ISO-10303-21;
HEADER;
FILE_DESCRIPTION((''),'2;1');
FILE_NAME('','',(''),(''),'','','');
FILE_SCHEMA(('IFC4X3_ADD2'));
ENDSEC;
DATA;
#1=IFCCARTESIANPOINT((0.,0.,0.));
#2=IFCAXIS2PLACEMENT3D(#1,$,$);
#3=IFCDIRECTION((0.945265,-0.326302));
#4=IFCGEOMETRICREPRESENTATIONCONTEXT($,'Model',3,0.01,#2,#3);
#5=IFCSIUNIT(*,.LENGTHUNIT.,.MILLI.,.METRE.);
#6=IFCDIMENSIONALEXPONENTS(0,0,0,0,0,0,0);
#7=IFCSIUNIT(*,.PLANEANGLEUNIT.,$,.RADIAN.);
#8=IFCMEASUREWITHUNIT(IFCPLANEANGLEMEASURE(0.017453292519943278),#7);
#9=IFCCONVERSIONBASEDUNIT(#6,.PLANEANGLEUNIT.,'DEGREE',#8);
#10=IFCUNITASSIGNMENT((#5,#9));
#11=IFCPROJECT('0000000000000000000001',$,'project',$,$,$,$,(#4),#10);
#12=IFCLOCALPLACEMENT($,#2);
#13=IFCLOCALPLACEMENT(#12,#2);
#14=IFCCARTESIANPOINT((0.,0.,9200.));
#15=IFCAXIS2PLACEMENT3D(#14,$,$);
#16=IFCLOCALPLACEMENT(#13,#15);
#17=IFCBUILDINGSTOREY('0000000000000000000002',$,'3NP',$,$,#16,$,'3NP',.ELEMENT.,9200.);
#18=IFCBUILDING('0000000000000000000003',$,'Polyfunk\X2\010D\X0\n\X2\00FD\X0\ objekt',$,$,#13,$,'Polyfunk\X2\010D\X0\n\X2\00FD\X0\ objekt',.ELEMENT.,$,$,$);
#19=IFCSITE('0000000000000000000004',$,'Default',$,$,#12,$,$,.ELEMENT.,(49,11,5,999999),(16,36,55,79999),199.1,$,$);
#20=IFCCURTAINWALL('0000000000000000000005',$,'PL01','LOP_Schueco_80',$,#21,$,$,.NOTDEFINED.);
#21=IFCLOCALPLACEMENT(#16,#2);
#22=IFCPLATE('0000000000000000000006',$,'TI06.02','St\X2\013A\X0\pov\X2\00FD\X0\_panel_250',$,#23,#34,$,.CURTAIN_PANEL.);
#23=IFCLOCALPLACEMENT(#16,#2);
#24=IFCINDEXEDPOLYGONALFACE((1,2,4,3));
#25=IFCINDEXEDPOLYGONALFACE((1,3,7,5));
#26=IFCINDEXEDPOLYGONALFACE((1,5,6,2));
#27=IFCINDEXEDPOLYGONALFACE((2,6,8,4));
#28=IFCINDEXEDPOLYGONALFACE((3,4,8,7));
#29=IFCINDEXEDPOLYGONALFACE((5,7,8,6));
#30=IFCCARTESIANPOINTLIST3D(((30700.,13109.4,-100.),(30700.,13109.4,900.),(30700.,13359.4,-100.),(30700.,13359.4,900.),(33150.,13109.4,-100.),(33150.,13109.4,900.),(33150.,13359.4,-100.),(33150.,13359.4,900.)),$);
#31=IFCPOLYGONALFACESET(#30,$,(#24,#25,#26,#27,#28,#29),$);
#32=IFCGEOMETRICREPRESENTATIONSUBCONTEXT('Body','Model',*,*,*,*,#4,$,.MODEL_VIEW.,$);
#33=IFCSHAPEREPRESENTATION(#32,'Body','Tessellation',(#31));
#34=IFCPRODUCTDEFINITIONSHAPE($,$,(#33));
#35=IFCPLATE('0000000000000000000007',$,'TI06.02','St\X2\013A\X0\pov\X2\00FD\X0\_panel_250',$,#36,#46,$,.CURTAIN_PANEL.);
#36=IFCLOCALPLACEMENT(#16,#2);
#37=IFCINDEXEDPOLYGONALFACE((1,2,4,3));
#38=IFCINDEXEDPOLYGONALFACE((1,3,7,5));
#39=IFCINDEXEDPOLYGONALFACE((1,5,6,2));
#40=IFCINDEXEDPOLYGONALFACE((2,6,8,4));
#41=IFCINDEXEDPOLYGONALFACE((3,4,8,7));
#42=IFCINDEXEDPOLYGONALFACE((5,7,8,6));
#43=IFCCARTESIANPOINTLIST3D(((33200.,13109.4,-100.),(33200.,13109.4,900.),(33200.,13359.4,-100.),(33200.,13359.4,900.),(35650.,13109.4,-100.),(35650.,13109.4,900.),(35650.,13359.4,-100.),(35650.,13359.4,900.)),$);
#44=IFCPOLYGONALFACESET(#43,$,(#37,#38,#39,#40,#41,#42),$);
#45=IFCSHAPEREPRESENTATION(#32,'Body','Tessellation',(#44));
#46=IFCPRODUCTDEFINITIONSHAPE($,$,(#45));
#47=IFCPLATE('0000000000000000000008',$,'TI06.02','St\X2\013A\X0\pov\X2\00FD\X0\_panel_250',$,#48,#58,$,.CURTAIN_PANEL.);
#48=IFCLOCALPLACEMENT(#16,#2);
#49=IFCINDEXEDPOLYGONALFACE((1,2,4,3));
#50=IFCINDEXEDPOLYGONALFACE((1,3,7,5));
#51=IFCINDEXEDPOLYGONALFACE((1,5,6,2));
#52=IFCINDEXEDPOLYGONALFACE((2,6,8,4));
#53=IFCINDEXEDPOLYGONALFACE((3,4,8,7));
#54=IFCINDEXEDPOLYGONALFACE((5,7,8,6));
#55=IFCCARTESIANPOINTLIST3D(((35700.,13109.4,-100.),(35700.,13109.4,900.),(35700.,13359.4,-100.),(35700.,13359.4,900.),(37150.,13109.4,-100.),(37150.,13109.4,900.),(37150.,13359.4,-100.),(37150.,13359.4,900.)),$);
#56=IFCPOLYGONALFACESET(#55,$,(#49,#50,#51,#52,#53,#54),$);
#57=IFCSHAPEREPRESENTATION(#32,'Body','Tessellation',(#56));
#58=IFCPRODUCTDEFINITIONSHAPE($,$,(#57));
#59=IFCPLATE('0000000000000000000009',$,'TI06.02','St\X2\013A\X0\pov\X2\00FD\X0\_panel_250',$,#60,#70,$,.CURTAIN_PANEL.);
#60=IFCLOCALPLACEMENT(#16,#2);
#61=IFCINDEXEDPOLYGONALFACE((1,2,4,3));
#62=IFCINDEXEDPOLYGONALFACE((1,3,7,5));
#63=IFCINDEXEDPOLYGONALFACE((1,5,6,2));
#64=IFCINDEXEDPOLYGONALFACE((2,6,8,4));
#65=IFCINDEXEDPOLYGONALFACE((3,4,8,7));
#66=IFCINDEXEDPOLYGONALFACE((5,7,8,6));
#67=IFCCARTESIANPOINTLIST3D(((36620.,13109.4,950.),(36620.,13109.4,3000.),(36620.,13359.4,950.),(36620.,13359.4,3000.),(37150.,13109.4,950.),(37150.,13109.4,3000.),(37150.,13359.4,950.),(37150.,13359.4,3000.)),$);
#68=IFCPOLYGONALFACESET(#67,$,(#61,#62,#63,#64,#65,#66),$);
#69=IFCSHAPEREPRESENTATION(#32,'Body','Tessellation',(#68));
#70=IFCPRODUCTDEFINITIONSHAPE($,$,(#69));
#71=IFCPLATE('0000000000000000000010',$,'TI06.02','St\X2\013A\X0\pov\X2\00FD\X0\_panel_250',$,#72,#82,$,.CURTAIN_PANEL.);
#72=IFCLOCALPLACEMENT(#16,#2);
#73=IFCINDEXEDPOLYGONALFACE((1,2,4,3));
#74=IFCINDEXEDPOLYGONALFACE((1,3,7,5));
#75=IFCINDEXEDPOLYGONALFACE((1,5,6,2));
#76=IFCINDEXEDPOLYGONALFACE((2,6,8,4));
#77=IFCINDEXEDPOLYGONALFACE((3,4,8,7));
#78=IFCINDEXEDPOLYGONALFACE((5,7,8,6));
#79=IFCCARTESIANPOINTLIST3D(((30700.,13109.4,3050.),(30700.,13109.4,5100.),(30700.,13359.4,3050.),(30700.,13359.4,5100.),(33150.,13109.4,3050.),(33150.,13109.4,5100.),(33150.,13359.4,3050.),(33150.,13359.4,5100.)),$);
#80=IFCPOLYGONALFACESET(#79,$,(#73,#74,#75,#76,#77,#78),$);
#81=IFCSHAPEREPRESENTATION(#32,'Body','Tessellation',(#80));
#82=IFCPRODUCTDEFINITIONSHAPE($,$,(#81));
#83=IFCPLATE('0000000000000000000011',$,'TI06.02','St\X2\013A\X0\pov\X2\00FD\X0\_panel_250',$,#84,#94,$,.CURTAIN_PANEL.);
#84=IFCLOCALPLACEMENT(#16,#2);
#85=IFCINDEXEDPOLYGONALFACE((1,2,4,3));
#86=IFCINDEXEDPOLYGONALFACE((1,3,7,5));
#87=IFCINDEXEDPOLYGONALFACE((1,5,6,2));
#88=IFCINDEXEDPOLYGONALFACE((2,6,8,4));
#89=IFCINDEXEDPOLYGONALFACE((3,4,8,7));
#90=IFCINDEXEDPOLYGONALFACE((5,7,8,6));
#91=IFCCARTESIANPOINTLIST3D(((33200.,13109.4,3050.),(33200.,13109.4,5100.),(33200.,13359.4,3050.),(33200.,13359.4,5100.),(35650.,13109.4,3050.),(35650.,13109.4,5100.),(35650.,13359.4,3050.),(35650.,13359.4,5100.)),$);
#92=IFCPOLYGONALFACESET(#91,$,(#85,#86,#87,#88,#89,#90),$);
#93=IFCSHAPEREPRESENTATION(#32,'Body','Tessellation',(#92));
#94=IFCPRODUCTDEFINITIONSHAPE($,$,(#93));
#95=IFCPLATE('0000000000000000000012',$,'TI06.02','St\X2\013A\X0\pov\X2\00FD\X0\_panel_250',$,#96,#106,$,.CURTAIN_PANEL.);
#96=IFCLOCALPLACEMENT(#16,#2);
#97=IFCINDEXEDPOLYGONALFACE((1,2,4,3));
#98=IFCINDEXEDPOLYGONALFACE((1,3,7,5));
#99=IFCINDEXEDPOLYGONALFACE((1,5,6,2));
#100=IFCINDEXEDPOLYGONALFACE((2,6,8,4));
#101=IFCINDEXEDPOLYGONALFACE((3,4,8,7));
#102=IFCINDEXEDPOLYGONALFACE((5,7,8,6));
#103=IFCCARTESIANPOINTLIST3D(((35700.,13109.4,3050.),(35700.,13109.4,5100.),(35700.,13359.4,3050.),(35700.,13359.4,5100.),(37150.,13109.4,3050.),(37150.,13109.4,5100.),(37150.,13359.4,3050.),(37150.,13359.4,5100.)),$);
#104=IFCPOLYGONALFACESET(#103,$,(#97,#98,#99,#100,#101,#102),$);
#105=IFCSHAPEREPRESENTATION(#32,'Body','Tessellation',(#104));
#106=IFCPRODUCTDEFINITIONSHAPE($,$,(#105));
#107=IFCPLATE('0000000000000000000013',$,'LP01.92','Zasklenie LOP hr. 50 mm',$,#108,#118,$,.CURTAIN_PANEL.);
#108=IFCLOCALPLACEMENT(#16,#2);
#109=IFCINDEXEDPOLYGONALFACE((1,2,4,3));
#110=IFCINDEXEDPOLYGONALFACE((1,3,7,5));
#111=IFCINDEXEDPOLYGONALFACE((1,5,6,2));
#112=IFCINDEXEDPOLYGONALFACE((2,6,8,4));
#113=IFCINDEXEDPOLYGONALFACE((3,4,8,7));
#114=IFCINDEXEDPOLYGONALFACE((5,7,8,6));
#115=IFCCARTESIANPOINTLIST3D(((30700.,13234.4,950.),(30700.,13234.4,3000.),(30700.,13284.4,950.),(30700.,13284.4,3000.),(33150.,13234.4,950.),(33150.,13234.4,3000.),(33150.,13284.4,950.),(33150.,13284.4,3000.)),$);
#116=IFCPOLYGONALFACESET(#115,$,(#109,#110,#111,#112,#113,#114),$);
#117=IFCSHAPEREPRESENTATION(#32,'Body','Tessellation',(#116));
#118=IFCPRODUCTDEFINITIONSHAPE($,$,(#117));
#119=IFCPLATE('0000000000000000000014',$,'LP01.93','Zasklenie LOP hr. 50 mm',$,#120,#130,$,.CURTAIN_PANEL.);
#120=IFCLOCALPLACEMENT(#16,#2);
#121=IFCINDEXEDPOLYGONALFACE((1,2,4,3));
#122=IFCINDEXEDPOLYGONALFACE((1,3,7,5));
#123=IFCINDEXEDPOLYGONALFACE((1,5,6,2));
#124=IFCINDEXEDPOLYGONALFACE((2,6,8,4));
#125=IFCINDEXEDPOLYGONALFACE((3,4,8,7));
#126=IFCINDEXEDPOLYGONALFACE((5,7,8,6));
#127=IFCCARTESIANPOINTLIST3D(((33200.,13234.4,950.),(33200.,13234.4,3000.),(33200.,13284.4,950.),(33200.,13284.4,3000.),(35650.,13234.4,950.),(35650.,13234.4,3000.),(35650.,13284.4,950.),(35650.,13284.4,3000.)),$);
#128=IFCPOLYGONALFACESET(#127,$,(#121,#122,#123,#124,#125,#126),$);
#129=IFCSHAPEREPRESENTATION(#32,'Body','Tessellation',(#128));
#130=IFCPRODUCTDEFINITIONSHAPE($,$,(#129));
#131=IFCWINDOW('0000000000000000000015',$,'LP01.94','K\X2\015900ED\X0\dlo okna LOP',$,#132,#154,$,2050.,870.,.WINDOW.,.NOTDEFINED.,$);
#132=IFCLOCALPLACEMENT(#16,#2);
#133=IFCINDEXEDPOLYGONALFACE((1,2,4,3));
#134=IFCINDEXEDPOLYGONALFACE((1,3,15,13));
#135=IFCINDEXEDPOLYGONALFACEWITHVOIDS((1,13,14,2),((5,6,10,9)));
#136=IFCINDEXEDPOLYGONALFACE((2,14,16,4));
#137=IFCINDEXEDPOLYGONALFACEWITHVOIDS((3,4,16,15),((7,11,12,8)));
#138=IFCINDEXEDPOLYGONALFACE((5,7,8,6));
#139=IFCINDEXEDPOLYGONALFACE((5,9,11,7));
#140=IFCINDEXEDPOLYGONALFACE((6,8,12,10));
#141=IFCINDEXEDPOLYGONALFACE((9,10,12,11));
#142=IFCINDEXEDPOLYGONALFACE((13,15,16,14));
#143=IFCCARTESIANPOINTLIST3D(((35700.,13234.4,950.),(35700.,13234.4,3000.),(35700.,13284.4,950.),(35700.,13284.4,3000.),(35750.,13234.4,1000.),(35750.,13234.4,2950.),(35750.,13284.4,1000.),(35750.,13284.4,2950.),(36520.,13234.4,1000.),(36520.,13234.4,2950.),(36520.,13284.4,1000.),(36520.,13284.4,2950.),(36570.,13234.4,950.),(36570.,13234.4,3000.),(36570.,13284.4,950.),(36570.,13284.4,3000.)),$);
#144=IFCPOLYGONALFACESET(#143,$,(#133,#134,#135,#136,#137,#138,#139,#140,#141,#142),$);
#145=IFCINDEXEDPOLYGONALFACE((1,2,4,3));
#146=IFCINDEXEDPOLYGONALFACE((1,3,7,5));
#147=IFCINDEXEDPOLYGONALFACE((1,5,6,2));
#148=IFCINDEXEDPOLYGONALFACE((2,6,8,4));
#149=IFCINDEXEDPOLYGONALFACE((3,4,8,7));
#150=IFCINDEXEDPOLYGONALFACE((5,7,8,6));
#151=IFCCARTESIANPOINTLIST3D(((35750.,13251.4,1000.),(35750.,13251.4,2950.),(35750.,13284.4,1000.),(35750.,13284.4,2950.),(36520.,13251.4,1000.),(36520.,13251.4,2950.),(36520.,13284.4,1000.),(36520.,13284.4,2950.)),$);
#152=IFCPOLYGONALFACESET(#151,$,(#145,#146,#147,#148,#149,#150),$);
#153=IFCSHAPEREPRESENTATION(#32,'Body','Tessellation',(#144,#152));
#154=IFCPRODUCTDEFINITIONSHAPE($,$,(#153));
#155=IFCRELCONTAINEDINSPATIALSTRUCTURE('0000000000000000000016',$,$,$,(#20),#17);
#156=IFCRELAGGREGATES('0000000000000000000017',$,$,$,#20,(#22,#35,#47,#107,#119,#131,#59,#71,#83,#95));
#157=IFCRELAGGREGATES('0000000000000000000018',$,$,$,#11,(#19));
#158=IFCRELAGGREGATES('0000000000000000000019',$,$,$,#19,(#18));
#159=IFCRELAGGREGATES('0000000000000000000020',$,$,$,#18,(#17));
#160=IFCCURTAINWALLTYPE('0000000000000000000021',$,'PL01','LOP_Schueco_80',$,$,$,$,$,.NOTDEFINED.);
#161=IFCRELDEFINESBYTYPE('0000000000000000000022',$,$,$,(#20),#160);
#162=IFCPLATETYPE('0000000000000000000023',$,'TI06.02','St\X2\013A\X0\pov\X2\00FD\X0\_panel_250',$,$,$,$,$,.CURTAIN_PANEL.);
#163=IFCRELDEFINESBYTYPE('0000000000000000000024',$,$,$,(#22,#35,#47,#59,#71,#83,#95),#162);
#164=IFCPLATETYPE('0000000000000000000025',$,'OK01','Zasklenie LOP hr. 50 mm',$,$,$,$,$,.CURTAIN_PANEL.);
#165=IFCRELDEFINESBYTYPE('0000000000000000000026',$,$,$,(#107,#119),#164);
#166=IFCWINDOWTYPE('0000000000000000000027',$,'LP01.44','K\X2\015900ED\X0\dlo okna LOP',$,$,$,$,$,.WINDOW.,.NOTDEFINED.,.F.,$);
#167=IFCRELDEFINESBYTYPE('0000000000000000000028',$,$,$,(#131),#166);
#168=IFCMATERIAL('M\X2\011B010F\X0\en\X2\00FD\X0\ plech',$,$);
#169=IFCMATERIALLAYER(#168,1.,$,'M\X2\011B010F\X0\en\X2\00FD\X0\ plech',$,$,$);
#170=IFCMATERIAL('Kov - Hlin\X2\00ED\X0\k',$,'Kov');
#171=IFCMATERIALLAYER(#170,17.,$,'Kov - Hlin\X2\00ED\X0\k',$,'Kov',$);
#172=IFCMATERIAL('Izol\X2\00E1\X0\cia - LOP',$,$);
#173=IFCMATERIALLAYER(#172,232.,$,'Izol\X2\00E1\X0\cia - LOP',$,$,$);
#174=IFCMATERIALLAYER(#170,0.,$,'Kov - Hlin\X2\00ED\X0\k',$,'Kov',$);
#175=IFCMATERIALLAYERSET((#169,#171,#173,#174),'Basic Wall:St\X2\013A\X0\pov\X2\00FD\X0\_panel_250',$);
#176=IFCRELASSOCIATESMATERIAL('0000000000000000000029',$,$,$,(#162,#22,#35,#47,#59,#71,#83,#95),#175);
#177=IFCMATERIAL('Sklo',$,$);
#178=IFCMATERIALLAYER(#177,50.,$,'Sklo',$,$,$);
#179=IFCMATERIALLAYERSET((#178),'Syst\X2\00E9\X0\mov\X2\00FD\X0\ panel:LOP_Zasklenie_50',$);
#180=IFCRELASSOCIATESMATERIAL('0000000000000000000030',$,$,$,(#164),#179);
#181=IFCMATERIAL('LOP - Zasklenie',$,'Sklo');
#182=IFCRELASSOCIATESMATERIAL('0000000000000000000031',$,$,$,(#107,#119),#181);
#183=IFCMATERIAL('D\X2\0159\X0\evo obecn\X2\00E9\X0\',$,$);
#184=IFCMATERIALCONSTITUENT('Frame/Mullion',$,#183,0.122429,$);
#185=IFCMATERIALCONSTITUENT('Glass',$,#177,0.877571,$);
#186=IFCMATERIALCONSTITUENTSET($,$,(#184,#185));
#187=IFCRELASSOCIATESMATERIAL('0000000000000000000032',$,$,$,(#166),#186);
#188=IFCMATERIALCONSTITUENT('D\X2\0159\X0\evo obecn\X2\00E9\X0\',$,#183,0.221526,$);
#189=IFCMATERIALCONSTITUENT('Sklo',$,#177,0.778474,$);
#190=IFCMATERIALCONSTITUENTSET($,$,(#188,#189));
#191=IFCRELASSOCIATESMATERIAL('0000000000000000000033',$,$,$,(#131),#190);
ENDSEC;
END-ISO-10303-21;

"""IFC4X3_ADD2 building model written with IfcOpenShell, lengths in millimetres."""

from ifc_helpers import new_model, entity, si_unit, converted_unit, direction, frame, frame_2d, origin, origin_2d_with_axis, place, context, subcontext, project, spatial, polyline, rectangle, outline, extrude, source, transform, mapped, material, layer, layer_set, layer_usage, constituent, constituent_set, type_object, type_shapes, element, aggregate, save


model = new_model("IFC4X3_ADD2")

# Units and contexts
model_context = context("Model", 3, precision=0.01, world=origin(), true_north=direction((0.945265, -0.326302)))
body_context = subcontext(model_context, "Body", "Model", "MODEL_VIEW")
ifc_project = project(units=[si_unit("LENGTHUNIT", "METRE", prefix="MILLI"), converted_unit("PLANEANGLEUNIT", "DEGREE", entity("IfcPlaneAngleMeasure", 0.017453292519943278), si_unit("PLANEANGLEUNIT", "RADIAN"), dimensions=[0, 0, 0, 0, 0, 0, 0])], contexts=[model_context])

# Site, building, storey
site_placement = place(None, origin())
site = spatial("IfcSite", under=ifc_project, at=site_placement, Name="Default", CompositionType="ELEMENT", RefLatitude=(49, 11, 5, 999999), RefLongitude=(16, 36, 55, 79999), RefElevation=199.1)
building_placement = place(site_placement, origin())
building = spatial("IfcBuilding", under=site, at=building_placement, Name="Polyfunkčný objekt", LongName="Polyfunkčný objekt", CompositionType="ELEMENT")
storey_placement = place(building_placement, frame((0.0, 0.0, 9200.0)))
storey = spatial("IfcBuildingStorey", under=building, at=storey_placement, Name="3NP", LongName="3NP", CompositionType="ELEMENT", Elevation=9200.0)

# Curtain wall, plates, window
curtain_wall_type = type_object("IfcCurtainWallType", Name="PL01", Description="LOP_Schueco_80", PredefinedType="NOTDEFINED")
curtain_wall_placement = place(storey_placement, frame((0.0, 0.0, -9200.0)))
curtain_wall = element("IfcCurtainWall", 1, at=curtain_wall_placement, inside=storey, type_object=curtain_wall_type, Name="PL01", Description="LOP_Schueco_80", PredefinedType="NOTDEFINED")
ifc_material_1 = material(Name="Měďený plech")
ifc_layer_1 = layer(ifc_material_1, 1.0, Name="Měďený plech")
ifc_material_2 = material(Name="Kov - Hliník", Category="Kov")
ifc_layer_2 = layer(ifc_material_2, 17.0, Name="Kov - Hliník", Category="Kov")
ifc_material_3 = material(Name="Izolácia - LOP")
ifc_layer_3 = layer(ifc_material_3, 232.0, Name="Izolácia - LOP")
ifc_layer_4 = layer(ifc_material_2, 0.0, Name="Kov - Hliník", Category="Kov")
ifc_layer_set_1 = layer_set([ifc_layer_1, ifc_layer_2, ifc_layer_3, ifc_layer_4], Name="Basic Wall:Stĺpový_panel_250")
ifc_layer_usage_1 = layer_usage(ifc_layer_set_1, "AXIS2", "NEGATIVE", 125.0)
plate_type_1 = type_object("IfcPlateType", Name="TI06.02", Description="Stĺpový_panel_250", PredefinedType="CURTAIN_PANEL", material=ifc_layer_set_1)
plate_1_placement = place(storey_placement, frame((30700.0, 13234.4, -100.0)))
plate_1 = element("IfcPlate", 2, at=plate_1_placement, type_object=plate_type_1, material=ifc_layer_usage_1, Name="TI06.02", Description="Stĺpový_panel_250", PredefinedType="CURTAIN_PANEL", context=body_context, shape_type="SweptSolid", body=[
    extrude(rectangle(XDim=250.0, YDim=2450.0, at=frame_2d((0.0, 0.0), x_axis=(1.0, 0.0))), frame((1225.0, 0.0, 0.0), z_axis=(0.0, 0.0, 1.0), x_axis=(0.0, 1.0, 0.0)), (0.0, 0.0, 1.0), 1000.0),
])
ifc_layer_usage_2 = layer_usage(ifc_layer_set_1, "AXIS2", "NEGATIVE", 125.0)
plate_2_placement = place(storey_placement, frame((33200.0, 13234.4, -100.0)))
plate_2 = element("IfcPlate", 3, at=plate_2_placement, type_object=plate_type_1, material=ifc_layer_usage_2, Name="TI06.02", Description="Stĺpový_panel_250", PredefinedType="CURTAIN_PANEL", context=body_context, shape_type="SweptSolid", body=[
    extrude(rectangle(XDim=250.0, YDim=2450.0, at=frame_2d((0.0, 0.0), x_axis=(1.0, 0.0))), frame((1225.0, 0.0, 0.0), z_axis=(0.0, 0.0, 1.0), x_axis=(0.0, 1.0, 0.0)), (0.0, 0.0, 1.0), 1000.0),
])
ifc_layer_usage_3 = layer_usage(ifc_layer_set_1, "AXIS2", "NEGATIVE", 125.0)
plate_3_placement = place(storey_placement, frame((35700.0, 13234.4, -100.0)))
plate_3 = element("IfcPlate", 4, at=plate_3_placement, type_object=plate_type_1, material=ifc_layer_usage_3, Name="TI06.02", Description="Stĺpový_panel_250", PredefinedType="CURTAIN_PANEL", context=body_context, shape_type="SweptSolid", body=[
    extrude(rectangle(XDim=250.0, YDim=1450.0, at=origin_2d_with_axis()), frame((725.0, 0.0, 0.0), z_axis=(0.0, 0.0, 1.0), x_axis=(0.0, 1.0, 0.0)), (0.0, 0.0, 1.0), 1000.0),
])
ifc_layer_usage_4 = layer_usage(ifc_layer_set_1, "AXIS2", "NEGATIVE", 125.0)
plate_4_placement = place(storey_placement, frame((36620.0, 13234.4, 950.0)))
plate_4 = element("IfcPlate", 5, at=plate_4_placement, type_object=plate_type_1, material=ifc_layer_usage_4, Name="TI06.02", Description="Stĺpový_panel_250", PredefinedType="CURTAIN_PANEL", context=body_context, shape_type="SweptSolid", body=[
    extrude(rectangle(XDim=250.0, YDim=530.0, at=frame_2d((0.0, 0.0), x_axis=(1.0, 0.0))), frame((265.0, 0.0, 0.0), z_axis=(0.0, 0.0, 1.0), x_axis=(0.0, 1.0, 0.0)), (0.0, 0.0, 1.0), 2050.0),
])
ifc_layer_usage_5 = layer_usage(ifc_layer_set_1, "AXIS2", "NEGATIVE", 125.0)
plate_5_placement = place(storey_placement, frame((30700.0, 13234.4, 3050.0)))
plate_5 = element("IfcPlate", 6, at=plate_5_placement, type_object=plate_type_1, material=ifc_layer_usage_5, Name="TI06.02", Description="Stĺpový_panel_250", PredefinedType="CURTAIN_PANEL", context=body_context, shape_type="SweptSolid", body=[
    extrude(rectangle(XDim=250.0, YDim=2450.0, at=frame_2d((0.0, 0.0), x_axis=(1.0, 0.0))), frame((1225.0, 0.0, 0.0), z_axis=(0.0, 0.0, 1.0), x_axis=(0.0, 1.0, 0.0)), (0.0, 0.0, 1.0), 2050.0),
])
ifc_layer_usage_6 = layer_usage(ifc_layer_set_1, "AXIS2", "NEGATIVE", 125.0)
plate_6_placement = place(storey_placement, frame((33200.0, 13234.4, 3050.0)))
plate_6 = element("IfcPlate", 7, at=plate_6_placement, type_object=plate_type_1, material=ifc_layer_usage_6, Name="TI06.02", Description="Stĺpový_panel_250", PredefinedType="CURTAIN_PANEL", context=body_context, shape_type="SweptSolid", body=[
    extrude(rectangle(XDim=250.0, YDim=2450.0, at=frame_2d((0.0, 0.0), x_axis=(1.0, 0.0))), frame((1225.0, 0.0, 0.0), z_axis=(0.0, 0.0, 1.0), x_axis=(0.0, 1.0, 0.0)), (0.0, 0.0, 1.0), 2050.0),
])
ifc_layer_usage_7 = layer_usage(ifc_layer_set_1, "AXIS2", "NEGATIVE", 125.0)
plate_7_placement = place(storey_placement, frame((35700.0, 13234.4, 3050.0)))
plate_7 = element("IfcPlate", 8, at=plate_7_placement, type_object=plate_type_1, material=ifc_layer_usage_7, Name="TI06.02", Description="Stĺpový_panel_250", PredefinedType="CURTAIN_PANEL", context=body_context, shape_type="SweptSolid", body=[
    extrude(rectangle(XDim=250.0, YDim=1450.0, at=origin_2d_with_axis()), frame((725.0, 0.0, 0.0), z_axis=(0.0, 0.0, 1.0), x_axis=(0.0, 1.0, 0.0)), (0.0, 0.0, 1.0), 2050.0),
])
ifc_material_4 = material(Name="LOP - Zasklenie", Category="Sklo")
ifc_material_5 = material(Name="Sklo")
ifc_layer_5 = layer(ifc_material_5, 50.0, Name="Sklo")
ifc_layer_set_2 = layer_set([ifc_layer_5], Name="Systémový panel:LOP_Zasklenie_50")
plate_type_2 = type_object("IfcPlateType", Name="OK01", Description="Zasklenie LOP hr. 50 mm", PredefinedType="CURTAIN_PANEL", material=ifc_layer_set_2)
shared_shape_1 = source(origin(), body_context, "Body", "SweptSolid", [
    extrude(rectangle(XDim=50.0, YDim=2450.0, at=origin_2d_with_axis()), frame((0.0, 25.0, 0.0), z_axis=(0.0, 0.0, 1.0), x_axis=(0.0, 1.0, 0.0)), (0.0, 0.0, 1.0), 2050.0),
])
type_shapes(plate_type_2, [shared_shape_1])
plate_8_placement = place(curtain_wall_placement, frame((31925.0, 13234.4, 10150.0)))
plate_8 = element("IfcPlate", 9, at=plate_8_placement, type_object=plate_type_2, material=ifc_material_4, Name="LP01.92", Description="Zasklenie LOP hr. 50 mm", PredefinedType="CURTAIN_PANEL", context=body_context, shape_type="MappedRepresentation", body=[
    mapped(shared_shape_1, transform((0.0, 0.0, 0.0), scale=1.0)),
])
plate_9_placement = place(curtain_wall_placement, frame((34425.0, 13234.4, 10150.0)))
plate_9 = element("IfcPlate", 10, at=plate_9_placement, type_object=plate_type_2, material=ifc_material_4, Name="LP01.93", Description="Zasklenie LOP hr. 50 mm", PredefinedType="CURTAIN_PANEL", context=body_context, shape_type="MappedRepresentation", body=[
    mapped(shared_shape_1, transform((0.0, 0.0, 0.0), scale=1.0)),
])
ifc_material_6 = material(Name="Dřevo obecné")
ifc_constituent_1 = constituent(ifc_material_6, Name="Dřevo obecné", fraction=0.221526)
ifc_constituent_2 = constituent(ifc_material_5, Name="Sklo", fraction=0.778474)
ifc_constituent_set_1 = constituent_set(constituents=[ifc_constituent_1, ifc_constituent_2])
ifc_constituent_3 = constituent(ifc_material_6, Name="Frame/Mullion", fraction=0.122429)
ifc_constituent_4 = constituent(ifc_material_5, Name="Glass", fraction=0.877571)
ifc_constituent_set_2 = constituent_set(constituents=[ifc_constituent_3, ifc_constituent_4])
window_type = type_object("IfcWindowType", Name="LP01.44", Description="Křídlo okna LOP", ParameterTakesPrecedence=False, PartitioningType="NOTDEFINED", PredefinedType="WINDOW", material=ifc_constituent_set_2)
shared_shape_2 = source(origin(), body_context, "Body", "SweptSolid", [
    extrude(outline(polyline([(-1025.0, -435.0), (1025.0, -435.0), (1025.0, 435.0), (-1025.0, 435.0), (-1025.0, -435.0)]), holes=[polyline([(-975.0, -385.0), (-975.0, 385.0), (975.0, 385.0), (975.0, -385.0), (-975.0, -385.0)])]), frame((0.0, 0.0, 1025.0), z_axis=(0.0, 1.0, 0.0), x_axis=(0.0, 0.0, -1.0)), (0.0, 0.0, 1.0), 50.0),
    extrude(rectangle(XDim=33.0, YDim=770.0, at=origin_2d_with_axis()), frame((0.0, 33.5, 50.0), z_axis=(0.0, 0.0, 1.0), x_axis=(0.0, -1.0, 0.0)), (0.0, 0.0, 1.0), 1950.0),
])
type_shapes(window_type, [shared_shape_2])
window_placement = place(curtain_wall_placement, frame((36135.0, 13234.4, 10150.0)))
window = element("IfcWindow", 11, at=window_placement, type_object=window_type, material=ifc_constituent_set_1, Name="LP01.94", Description="Křídlo okna LOP", OverallHeight=2050.0, OverallWidth=870.0, PartitioningType="NOTDEFINED", PredefinedType="WINDOW", context=body_context, shape_type="MappedRepresentation", body=[
    mapped(shared_shape_2, transform((0.0, 0.0, 0.0), scale=1.0)),
])
aggregate(curtain_wall, [plate_1, plate_2, plate_3, plate_8, plate_9, window, plate_4, plate_5, plate_6, plate_7])

save(model, "model.ifc")
